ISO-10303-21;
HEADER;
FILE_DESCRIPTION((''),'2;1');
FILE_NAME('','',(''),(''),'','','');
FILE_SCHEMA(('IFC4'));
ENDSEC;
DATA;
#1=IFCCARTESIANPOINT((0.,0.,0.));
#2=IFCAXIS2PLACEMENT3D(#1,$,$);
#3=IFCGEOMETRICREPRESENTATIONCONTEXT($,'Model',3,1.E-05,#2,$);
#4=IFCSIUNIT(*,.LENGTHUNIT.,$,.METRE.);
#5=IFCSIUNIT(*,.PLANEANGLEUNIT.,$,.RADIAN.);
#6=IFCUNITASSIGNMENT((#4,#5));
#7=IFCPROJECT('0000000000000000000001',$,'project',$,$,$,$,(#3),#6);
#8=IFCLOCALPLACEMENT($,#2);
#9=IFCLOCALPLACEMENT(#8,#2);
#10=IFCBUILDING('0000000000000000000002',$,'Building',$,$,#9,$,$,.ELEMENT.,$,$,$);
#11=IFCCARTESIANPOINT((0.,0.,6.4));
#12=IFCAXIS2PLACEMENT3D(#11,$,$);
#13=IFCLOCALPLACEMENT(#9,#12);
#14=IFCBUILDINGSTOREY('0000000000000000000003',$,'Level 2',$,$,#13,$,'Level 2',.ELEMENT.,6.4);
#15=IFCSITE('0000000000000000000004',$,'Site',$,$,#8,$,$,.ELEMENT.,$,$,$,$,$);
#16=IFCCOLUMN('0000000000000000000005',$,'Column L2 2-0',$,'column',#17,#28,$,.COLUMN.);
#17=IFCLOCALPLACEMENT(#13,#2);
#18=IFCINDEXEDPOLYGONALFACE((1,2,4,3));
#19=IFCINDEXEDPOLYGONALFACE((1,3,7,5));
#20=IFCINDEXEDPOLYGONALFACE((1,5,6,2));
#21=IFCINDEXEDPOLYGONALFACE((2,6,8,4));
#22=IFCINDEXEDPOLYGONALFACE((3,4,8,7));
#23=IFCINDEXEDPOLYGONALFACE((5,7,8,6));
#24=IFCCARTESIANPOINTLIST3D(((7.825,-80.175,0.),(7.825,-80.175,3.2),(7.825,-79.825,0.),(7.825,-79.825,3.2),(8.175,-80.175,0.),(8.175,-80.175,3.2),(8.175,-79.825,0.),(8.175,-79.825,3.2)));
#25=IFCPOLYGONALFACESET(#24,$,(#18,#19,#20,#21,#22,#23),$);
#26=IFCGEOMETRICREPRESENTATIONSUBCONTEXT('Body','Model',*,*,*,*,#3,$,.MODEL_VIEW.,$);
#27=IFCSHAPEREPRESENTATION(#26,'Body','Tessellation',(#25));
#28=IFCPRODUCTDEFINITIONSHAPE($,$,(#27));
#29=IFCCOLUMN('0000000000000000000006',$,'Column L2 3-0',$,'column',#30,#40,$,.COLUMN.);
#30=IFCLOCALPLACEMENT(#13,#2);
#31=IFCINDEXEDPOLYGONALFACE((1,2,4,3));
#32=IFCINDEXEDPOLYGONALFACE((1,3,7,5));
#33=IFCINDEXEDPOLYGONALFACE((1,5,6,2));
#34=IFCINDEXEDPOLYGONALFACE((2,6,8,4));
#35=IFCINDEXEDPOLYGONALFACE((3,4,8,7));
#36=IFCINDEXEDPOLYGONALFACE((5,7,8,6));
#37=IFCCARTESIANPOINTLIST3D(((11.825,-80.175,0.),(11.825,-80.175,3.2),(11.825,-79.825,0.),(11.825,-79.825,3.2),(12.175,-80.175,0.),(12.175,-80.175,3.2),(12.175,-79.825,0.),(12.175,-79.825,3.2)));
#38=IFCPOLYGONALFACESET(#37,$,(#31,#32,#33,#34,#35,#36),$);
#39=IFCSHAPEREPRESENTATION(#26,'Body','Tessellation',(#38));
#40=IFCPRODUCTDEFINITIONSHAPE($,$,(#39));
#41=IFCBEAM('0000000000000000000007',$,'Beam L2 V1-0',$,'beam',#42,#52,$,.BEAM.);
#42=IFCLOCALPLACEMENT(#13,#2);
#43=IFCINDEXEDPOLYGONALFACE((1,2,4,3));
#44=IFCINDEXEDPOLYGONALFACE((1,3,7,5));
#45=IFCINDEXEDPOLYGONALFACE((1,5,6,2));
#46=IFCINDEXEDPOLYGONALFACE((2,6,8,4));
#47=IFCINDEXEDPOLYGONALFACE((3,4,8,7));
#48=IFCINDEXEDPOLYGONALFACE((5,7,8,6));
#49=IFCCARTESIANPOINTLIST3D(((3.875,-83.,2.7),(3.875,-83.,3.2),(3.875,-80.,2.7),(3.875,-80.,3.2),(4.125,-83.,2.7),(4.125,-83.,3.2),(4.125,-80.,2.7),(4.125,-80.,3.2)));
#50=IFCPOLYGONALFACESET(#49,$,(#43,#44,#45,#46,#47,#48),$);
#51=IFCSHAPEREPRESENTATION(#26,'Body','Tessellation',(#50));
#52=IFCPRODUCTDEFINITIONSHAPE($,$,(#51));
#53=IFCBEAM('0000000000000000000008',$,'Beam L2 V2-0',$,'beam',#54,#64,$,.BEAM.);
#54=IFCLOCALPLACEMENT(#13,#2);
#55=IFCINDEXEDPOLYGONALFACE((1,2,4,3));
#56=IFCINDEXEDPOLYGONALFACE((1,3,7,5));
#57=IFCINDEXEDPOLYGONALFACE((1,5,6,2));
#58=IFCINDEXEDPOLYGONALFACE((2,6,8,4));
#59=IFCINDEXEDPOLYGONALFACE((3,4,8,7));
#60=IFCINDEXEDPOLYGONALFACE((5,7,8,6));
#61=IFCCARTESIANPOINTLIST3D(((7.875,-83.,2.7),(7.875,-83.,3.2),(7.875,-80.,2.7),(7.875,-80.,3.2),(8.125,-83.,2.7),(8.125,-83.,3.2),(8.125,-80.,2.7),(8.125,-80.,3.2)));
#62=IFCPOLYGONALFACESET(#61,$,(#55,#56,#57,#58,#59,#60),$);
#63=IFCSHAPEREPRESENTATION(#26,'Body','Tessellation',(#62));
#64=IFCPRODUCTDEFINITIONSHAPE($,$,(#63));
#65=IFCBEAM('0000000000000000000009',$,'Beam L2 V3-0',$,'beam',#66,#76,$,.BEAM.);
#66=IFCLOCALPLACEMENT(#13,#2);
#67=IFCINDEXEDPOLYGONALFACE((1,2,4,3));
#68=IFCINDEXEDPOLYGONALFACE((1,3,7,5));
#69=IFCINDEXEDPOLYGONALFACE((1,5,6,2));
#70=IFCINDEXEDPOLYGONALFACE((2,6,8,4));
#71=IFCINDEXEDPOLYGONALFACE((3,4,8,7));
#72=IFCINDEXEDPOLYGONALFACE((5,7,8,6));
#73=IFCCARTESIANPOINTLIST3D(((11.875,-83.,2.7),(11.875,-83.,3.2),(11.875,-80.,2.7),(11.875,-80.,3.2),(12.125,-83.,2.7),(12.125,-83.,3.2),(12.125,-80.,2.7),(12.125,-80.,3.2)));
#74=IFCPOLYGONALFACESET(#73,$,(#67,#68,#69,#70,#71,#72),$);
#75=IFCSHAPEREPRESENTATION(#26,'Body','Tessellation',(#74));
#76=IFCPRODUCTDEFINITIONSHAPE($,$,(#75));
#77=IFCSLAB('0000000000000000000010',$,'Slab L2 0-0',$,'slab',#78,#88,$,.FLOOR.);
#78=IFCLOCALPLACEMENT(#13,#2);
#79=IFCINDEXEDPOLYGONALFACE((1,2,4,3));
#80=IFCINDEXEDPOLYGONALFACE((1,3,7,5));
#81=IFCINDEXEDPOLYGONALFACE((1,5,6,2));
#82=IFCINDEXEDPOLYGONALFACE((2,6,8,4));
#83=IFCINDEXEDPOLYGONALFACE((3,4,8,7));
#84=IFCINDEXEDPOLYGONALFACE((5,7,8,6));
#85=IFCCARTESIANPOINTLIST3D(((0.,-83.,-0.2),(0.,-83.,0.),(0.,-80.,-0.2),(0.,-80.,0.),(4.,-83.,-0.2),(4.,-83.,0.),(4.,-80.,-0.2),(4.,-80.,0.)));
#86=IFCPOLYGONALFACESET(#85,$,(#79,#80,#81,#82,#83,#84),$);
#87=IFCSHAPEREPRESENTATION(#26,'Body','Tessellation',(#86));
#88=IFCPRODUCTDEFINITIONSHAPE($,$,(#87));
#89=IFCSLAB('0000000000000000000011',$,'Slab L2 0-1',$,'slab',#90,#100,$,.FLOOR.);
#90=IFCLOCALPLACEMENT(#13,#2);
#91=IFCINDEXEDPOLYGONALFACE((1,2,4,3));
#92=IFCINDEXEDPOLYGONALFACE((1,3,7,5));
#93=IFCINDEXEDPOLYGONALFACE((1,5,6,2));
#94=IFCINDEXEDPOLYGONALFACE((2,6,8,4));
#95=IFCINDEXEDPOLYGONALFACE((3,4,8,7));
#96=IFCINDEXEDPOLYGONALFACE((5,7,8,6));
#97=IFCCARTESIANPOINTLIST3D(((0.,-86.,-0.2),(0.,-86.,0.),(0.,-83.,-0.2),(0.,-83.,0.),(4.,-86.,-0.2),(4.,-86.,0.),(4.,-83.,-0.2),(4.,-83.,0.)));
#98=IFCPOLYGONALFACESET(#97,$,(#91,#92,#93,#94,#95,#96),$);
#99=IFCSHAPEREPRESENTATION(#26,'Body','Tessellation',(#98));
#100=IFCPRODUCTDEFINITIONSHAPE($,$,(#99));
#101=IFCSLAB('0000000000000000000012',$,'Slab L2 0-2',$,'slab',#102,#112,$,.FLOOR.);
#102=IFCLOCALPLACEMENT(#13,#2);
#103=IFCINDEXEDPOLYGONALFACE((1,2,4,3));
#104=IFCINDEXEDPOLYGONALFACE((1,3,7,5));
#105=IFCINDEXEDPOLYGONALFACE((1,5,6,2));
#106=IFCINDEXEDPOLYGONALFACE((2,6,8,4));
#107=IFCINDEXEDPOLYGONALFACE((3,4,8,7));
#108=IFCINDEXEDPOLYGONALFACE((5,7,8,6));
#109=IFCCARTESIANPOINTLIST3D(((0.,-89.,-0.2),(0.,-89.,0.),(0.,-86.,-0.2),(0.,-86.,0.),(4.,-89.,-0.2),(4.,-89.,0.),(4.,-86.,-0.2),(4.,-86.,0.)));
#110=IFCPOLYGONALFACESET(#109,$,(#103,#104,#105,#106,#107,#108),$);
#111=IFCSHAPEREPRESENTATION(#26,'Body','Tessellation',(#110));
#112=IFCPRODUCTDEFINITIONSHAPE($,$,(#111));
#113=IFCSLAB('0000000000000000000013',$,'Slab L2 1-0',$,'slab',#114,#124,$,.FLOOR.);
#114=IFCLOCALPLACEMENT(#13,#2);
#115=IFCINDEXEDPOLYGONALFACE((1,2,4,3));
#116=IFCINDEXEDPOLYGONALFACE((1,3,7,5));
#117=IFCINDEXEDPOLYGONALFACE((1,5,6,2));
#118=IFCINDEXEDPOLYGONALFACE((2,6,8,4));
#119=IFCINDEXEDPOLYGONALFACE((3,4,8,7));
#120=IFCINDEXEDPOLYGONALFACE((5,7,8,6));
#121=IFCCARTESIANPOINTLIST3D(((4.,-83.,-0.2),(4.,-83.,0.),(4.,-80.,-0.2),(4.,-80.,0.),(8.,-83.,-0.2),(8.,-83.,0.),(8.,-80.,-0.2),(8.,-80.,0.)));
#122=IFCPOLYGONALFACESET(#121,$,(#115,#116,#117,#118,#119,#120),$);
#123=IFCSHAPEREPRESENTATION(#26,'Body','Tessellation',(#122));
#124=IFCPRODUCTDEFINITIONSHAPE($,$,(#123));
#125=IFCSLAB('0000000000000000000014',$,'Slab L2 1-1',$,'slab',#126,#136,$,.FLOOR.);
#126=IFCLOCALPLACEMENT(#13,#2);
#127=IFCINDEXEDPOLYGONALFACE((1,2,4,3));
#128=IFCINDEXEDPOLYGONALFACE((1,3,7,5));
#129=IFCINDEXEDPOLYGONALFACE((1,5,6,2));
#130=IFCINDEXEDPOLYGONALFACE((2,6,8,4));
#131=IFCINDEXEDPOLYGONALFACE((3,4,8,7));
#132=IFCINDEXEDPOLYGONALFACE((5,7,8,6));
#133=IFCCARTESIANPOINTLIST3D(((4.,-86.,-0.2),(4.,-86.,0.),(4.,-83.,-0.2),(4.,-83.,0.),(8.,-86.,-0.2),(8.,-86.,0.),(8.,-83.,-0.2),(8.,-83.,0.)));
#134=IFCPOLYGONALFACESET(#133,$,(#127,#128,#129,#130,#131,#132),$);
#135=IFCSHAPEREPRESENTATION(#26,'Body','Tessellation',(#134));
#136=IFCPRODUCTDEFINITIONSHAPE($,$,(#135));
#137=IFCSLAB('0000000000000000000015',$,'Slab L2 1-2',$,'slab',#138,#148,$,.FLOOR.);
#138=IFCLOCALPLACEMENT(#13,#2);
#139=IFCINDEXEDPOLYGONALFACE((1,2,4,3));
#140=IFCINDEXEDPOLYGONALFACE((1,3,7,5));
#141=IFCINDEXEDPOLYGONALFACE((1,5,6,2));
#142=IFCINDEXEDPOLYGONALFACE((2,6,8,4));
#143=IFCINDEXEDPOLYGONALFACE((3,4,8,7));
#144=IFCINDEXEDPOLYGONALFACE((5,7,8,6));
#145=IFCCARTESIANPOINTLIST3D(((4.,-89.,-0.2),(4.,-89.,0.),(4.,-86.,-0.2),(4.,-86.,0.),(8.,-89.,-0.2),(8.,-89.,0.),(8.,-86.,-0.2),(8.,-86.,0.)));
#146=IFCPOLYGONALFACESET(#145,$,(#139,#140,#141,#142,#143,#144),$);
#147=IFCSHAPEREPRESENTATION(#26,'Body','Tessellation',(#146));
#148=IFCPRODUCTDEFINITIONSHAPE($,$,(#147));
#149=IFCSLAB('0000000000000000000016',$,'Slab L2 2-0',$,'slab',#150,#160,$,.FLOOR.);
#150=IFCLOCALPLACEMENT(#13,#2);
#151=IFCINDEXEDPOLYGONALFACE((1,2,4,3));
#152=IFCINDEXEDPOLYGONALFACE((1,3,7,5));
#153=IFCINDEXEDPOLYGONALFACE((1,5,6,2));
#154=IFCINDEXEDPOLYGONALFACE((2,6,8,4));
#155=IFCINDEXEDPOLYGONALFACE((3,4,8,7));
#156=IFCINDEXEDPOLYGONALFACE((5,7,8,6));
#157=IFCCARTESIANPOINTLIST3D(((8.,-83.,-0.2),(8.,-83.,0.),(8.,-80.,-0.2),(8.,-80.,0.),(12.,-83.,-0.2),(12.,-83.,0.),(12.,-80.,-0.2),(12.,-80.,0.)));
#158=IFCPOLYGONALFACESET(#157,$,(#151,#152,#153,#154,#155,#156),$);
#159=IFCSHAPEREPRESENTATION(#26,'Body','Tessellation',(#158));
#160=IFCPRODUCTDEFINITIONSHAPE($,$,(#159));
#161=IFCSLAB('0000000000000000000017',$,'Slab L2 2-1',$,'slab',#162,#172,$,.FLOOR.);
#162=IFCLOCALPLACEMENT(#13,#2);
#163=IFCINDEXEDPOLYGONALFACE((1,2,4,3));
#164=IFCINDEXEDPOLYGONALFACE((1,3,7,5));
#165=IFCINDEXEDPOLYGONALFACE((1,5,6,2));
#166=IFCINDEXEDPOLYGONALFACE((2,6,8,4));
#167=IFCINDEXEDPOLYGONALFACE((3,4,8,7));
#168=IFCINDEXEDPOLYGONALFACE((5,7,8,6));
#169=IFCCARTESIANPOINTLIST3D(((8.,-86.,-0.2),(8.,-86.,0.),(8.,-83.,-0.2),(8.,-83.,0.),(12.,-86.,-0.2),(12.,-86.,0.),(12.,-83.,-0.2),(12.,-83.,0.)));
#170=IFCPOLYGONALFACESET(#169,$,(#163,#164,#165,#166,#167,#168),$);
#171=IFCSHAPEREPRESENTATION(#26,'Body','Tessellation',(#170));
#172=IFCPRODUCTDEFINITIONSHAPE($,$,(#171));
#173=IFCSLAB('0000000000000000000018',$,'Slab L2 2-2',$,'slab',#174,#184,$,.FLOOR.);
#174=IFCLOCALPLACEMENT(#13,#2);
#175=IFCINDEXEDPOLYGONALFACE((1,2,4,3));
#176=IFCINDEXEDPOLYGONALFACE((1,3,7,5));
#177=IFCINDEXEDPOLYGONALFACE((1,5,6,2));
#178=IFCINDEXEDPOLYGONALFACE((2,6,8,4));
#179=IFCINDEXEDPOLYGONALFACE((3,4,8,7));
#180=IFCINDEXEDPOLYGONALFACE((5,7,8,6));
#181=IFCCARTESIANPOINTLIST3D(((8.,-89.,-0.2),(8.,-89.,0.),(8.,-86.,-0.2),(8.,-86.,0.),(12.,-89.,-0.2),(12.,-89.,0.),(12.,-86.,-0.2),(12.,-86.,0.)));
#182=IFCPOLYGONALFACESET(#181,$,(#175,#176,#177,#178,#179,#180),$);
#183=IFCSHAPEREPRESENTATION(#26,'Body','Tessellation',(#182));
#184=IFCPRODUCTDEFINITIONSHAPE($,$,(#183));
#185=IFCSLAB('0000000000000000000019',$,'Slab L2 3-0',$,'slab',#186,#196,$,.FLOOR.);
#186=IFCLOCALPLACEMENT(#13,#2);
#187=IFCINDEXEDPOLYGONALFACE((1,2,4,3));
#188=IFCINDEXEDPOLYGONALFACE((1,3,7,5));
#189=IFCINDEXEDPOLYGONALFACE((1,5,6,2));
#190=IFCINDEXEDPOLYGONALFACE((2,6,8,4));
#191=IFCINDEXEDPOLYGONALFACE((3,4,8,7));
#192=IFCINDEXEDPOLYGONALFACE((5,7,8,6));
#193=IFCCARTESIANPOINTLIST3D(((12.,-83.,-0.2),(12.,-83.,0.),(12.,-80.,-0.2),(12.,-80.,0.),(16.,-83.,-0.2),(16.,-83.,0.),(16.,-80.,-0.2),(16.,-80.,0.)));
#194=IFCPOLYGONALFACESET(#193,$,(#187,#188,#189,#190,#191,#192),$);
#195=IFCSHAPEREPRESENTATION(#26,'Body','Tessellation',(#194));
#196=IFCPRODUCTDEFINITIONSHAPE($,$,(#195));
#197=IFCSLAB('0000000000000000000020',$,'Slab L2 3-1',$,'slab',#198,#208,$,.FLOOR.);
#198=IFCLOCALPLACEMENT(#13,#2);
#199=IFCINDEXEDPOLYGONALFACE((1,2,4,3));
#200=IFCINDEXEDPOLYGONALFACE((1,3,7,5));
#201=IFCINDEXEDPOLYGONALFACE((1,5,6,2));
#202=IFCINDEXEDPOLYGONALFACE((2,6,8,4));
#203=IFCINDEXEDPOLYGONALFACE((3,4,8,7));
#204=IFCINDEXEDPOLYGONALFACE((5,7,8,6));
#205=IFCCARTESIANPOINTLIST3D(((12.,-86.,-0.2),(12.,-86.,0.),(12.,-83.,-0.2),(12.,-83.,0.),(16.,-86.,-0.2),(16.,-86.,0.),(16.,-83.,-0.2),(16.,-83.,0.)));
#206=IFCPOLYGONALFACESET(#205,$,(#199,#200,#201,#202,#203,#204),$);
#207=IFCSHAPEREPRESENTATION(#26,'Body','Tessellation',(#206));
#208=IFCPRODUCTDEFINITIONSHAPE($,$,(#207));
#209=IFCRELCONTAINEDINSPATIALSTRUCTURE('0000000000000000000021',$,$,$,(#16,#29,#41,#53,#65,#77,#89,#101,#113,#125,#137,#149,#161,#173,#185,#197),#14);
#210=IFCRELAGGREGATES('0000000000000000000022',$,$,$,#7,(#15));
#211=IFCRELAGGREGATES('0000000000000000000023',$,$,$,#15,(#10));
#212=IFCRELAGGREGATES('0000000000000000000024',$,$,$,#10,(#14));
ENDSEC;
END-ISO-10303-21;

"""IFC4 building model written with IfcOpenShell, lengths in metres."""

from ifc_helpers import new_model, si_unit, frame, origin, origin_2d, place, context, subcontext, project, spatial, polyline, rectangle, outline, extrude, element, save


model = new_model("IFC4")

# Units and contexts
model_context = context("Model", 3, precision=1e-05, world=origin())
body_context = subcontext(model_context, "Body", "Model", "MODEL_VIEW")
ifc_project = project(units=[si_unit("LENGTHUNIT", "METRE"), si_unit("PLANEANGLEUNIT", "RADIAN")], contexts=[model_context])

# Site, building, storey
site_placement = place(None, origin())
site = spatial("IfcSite", under=ifc_project, at=site_placement, Name="Site", CompositionType="ELEMENT")
building_placement = place(site_placement, origin())
building = spatial("IfcBuilding", under=site, at=building_placement, Name="Building", CompositionType="ELEMENT")
storey_placement = place(building_placement, frame((0.0, 0.0, 6.4)))
storey = spatial("IfcBuildingStorey", under=building, at=storey_placement, Name="Level 2", LongName="Level 2", CompositionType="ELEMENT", Elevation=6.4)

# Columns
for number, where, name in (
    (1, (8.0, -80.0, 0.0), "Column L2 2-0"),
    (2, (12.0, -80.0, 0.0), "Column L2 3-0"),
):
    element("IfcColumn", number, at=place(storey_placement, frame(where)), inside=storey, Name=name, ObjectType="column", PredefinedType="COLUMN", context=body_context, shape_type="SweptSolid", body=[
        extrude(rectangle(XDim=0.35, YDim=0.35, at=origin_2d()), origin(), (0.0, 0.0, 1.0), 3.2),
    ])

# Beams
for number, where, z_axis, x_axis, name in (
    (3, (4.0, -80.0, 2.95), (0.0, -1.0, 0.0), (0.0, 0.0, 1.0), "Beam L2 V1-0"),
    (4, (8.0, -80.0, 2.95), (0.0, -1.0, 0.0), (0.0, 0.0, 1.0), "Beam L2 V2-0"),
    (5, (12.0, -80.0, 2.95), (0.0, -1.0, 0.0), (0.0, 0.0, 1.0), "Beam L2 V3-0"),
):
    element("IfcBeam", number, at=place(storey_placement, frame(where, z_axis=z_axis, x_axis=x_axis)), inside=storey, Name=name, ObjectType="beam", PredefinedType="BEAM", context=body_context, shape_type="SweptSolid", body=[
        extrude(rectangle(XDim=0.5, YDim=0.25, at=origin_2d()), origin(), (0.0, 0.0, 1.0), 3.0),
    ])

# Slabs
slab_1_placement = place(storey_placement, frame((0.0, 0.0, -0.2)))
element("IfcSlab", 6, at=slab_1_placement, inside=storey, Name="Slab L2 0-0", ObjectType="slab", PredefinedType="FLOOR", context=body_context, shape_type="SweptSolid", body=[
    extrude(outline(polyline([(0.0, -83.0), (4.0, -83.0), (4.0, -80.0), (0.0, -80.0), (0.0, -83.0)])), origin(), (0.0, 0.0, 1.0), 0.2),
])
slab_2_placement = place(storey_placement, frame((0.0, 0.0, -0.2)))
element("IfcSlab", 7, at=slab_2_placement, inside=storey, Name="Slab L2 0-1", ObjectType="slab", PredefinedType="FLOOR", context=body_context, shape_type="SweptSolid", body=[
    extrude(outline(polyline([(0.0, -86.0), (4.0, -86.0), (4.0, -83.0), (0.0, -83.0), (0.0, -86.0)])), origin(), (0.0, 0.0, 1.0), 0.2),
])
slab_3_placement = place(storey_placement, frame((0.0, 0.0, -0.2)))
element("IfcSlab", 8, at=slab_3_placement, inside=storey, Name="Slab L2 0-2", ObjectType="slab", PredefinedType="FLOOR", context=body_context, shape_type="SweptSolid", body=[
    extrude(outline(polyline([(0.0, -89.0), (4.0, -89.0), (4.0, -86.0), (0.0, -86.0), (0.0, -89.0)])), origin(), (0.0, 0.0, 1.0), 0.2),
])
slab_4_placement = place(storey_placement, frame((0.0, 0.0, -0.2)))
element("IfcSlab", 9, at=slab_4_placement, inside=storey, Name="Slab L2 1-0", ObjectType="slab", PredefinedType="FLOOR", context=body_context, shape_type="SweptSolid", body=[
    extrude(outline(polyline([(4.0, -83.0), (8.0, -83.0), (8.0, -80.0), (4.0, -80.0), (4.0, -83.0)])), origin(), (0.0, 0.0, 1.0), 0.2),
])
slab_5_placement = place(storey_placement, frame((0.0, 0.0, -0.2)))
element("IfcSlab", 10, at=slab_5_placement, inside=storey, Name="Slab L2 1-1", ObjectType="slab", PredefinedType="FLOOR", context=body_context, shape_type="SweptSolid", body=[
    extrude(outline(polyline([(4.0, -86.0), (8.0, -86.0), (8.0, -83.0), (4.0, -83.0), (4.0, -86.0)])), origin(), (0.0, 0.0, 1.0), 0.2),
])
slab_6_placement = place(storey_placement, frame((0.0, 0.0, -0.2)))
element("IfcSlab", 11, at=slab_6_placement, inside=storey, Name="Slab L2 1-2", ObjectType="slab", PredefinedType="FLOOR", context=body_context, shape_type="SweptSolid", body=[
    extrude(outline(polyline([(4.0, -89.0), (8.0, -89.0), (8.0, -86.0), (4.0, -86.0), (4.0, -89.0)])), origin(), (0.0, 0.0, 1.0), 0.2),
])
slab_7_placement = place(storey_placement, frame((0.0, 0.0, -0.2)))
element("IfcSlab", 12, at=slab_7_placement, inside=storey, Name="Slab L2 2-0", ObjectType="slab", PredefinedType="FLOOR", context=body_context, shape_type="SweptSolid", body=[
    extrude(outline(polyline([(8.0, -83.0), (12.0, -83.0), (12.0, -80.0), (8.0, -80.0), (8.0, -83.0)])), origin(), (0.0, 0.0, 1.0), 0.2),
])
slab_8_placement = place(storey_placement, frame((0.0, 0.0, -0.2)))
element("IfcSlab", 13, at=slab_8_placement, inside=storey, Name="Slab L2 2-1", ObjectType="slab", PredefinedType="FLOOR", context=body_context, shape_type="SweptSolid", body=[
    extrude(outline(polyline([(8.0, -86.0), (12.0, -86.0), (12.0, -83.0), (8.0, -83.0), (8.0, -86.0)])), origin(), (0.0, 0.0, 1.0), 0.2),
])
slab_9_placement = place(storey_placement, frame((0.0, 0.0, -0.2)))
element("IfcSlab", 14, at=slab_9_placement, inside=storey, Name="Slab L2 2-2", ObjectType="slab", PredefinedType="FLOOR", context=body_context, shape_type="SweptSolid", body=[
    extrude(outline(polyline([(8.0, -89.0), (12.0, -89.0), (12.0, -86.0), (8.0, -86.0), (8.0, -89.0)])), origin(), (0.0, 0.0, 1.0), 0.2),
])
slab_10_placement = place(storey_placement, frame((0.0, 0.0, -0.2)))
element("IfcSlab", 15, at=slab_10_placement, inside=storey, Name="Slab L2 3-0", ObjectType="slab", PredefinedType="FLOOR", context=body_context, shape_type="SweptSolid", body=[
    extrude(outline(polyline([(12.0, -83.0), (16.0, -83.0), (16.0, -80.0), (12.0, -80.0), (12.0, -83.0)])), origin(), (0.0, 0.0, 1.0), 0.2),
])
slab_11_placement = place(storey_placement, frame((0.0, 0.0, -0.2)))
element("IfcSlab", 16, at=slab_11_placement, inside=storey, Name="Slab L2 3-1", ObjectType="slab", PredefinedType="FLOOR", context=body_context, shape_type="SweptSolid", body=[
    extrude(outline(polyline([(12.0, -86.0), (16.0, -86.0), (16.0, -83.0), (12.0, -83.0), (12.0, -86.0)])), origin(), (0.0, 0.0, 1.0), 0.2),
])

save(model, "model.ifc")
